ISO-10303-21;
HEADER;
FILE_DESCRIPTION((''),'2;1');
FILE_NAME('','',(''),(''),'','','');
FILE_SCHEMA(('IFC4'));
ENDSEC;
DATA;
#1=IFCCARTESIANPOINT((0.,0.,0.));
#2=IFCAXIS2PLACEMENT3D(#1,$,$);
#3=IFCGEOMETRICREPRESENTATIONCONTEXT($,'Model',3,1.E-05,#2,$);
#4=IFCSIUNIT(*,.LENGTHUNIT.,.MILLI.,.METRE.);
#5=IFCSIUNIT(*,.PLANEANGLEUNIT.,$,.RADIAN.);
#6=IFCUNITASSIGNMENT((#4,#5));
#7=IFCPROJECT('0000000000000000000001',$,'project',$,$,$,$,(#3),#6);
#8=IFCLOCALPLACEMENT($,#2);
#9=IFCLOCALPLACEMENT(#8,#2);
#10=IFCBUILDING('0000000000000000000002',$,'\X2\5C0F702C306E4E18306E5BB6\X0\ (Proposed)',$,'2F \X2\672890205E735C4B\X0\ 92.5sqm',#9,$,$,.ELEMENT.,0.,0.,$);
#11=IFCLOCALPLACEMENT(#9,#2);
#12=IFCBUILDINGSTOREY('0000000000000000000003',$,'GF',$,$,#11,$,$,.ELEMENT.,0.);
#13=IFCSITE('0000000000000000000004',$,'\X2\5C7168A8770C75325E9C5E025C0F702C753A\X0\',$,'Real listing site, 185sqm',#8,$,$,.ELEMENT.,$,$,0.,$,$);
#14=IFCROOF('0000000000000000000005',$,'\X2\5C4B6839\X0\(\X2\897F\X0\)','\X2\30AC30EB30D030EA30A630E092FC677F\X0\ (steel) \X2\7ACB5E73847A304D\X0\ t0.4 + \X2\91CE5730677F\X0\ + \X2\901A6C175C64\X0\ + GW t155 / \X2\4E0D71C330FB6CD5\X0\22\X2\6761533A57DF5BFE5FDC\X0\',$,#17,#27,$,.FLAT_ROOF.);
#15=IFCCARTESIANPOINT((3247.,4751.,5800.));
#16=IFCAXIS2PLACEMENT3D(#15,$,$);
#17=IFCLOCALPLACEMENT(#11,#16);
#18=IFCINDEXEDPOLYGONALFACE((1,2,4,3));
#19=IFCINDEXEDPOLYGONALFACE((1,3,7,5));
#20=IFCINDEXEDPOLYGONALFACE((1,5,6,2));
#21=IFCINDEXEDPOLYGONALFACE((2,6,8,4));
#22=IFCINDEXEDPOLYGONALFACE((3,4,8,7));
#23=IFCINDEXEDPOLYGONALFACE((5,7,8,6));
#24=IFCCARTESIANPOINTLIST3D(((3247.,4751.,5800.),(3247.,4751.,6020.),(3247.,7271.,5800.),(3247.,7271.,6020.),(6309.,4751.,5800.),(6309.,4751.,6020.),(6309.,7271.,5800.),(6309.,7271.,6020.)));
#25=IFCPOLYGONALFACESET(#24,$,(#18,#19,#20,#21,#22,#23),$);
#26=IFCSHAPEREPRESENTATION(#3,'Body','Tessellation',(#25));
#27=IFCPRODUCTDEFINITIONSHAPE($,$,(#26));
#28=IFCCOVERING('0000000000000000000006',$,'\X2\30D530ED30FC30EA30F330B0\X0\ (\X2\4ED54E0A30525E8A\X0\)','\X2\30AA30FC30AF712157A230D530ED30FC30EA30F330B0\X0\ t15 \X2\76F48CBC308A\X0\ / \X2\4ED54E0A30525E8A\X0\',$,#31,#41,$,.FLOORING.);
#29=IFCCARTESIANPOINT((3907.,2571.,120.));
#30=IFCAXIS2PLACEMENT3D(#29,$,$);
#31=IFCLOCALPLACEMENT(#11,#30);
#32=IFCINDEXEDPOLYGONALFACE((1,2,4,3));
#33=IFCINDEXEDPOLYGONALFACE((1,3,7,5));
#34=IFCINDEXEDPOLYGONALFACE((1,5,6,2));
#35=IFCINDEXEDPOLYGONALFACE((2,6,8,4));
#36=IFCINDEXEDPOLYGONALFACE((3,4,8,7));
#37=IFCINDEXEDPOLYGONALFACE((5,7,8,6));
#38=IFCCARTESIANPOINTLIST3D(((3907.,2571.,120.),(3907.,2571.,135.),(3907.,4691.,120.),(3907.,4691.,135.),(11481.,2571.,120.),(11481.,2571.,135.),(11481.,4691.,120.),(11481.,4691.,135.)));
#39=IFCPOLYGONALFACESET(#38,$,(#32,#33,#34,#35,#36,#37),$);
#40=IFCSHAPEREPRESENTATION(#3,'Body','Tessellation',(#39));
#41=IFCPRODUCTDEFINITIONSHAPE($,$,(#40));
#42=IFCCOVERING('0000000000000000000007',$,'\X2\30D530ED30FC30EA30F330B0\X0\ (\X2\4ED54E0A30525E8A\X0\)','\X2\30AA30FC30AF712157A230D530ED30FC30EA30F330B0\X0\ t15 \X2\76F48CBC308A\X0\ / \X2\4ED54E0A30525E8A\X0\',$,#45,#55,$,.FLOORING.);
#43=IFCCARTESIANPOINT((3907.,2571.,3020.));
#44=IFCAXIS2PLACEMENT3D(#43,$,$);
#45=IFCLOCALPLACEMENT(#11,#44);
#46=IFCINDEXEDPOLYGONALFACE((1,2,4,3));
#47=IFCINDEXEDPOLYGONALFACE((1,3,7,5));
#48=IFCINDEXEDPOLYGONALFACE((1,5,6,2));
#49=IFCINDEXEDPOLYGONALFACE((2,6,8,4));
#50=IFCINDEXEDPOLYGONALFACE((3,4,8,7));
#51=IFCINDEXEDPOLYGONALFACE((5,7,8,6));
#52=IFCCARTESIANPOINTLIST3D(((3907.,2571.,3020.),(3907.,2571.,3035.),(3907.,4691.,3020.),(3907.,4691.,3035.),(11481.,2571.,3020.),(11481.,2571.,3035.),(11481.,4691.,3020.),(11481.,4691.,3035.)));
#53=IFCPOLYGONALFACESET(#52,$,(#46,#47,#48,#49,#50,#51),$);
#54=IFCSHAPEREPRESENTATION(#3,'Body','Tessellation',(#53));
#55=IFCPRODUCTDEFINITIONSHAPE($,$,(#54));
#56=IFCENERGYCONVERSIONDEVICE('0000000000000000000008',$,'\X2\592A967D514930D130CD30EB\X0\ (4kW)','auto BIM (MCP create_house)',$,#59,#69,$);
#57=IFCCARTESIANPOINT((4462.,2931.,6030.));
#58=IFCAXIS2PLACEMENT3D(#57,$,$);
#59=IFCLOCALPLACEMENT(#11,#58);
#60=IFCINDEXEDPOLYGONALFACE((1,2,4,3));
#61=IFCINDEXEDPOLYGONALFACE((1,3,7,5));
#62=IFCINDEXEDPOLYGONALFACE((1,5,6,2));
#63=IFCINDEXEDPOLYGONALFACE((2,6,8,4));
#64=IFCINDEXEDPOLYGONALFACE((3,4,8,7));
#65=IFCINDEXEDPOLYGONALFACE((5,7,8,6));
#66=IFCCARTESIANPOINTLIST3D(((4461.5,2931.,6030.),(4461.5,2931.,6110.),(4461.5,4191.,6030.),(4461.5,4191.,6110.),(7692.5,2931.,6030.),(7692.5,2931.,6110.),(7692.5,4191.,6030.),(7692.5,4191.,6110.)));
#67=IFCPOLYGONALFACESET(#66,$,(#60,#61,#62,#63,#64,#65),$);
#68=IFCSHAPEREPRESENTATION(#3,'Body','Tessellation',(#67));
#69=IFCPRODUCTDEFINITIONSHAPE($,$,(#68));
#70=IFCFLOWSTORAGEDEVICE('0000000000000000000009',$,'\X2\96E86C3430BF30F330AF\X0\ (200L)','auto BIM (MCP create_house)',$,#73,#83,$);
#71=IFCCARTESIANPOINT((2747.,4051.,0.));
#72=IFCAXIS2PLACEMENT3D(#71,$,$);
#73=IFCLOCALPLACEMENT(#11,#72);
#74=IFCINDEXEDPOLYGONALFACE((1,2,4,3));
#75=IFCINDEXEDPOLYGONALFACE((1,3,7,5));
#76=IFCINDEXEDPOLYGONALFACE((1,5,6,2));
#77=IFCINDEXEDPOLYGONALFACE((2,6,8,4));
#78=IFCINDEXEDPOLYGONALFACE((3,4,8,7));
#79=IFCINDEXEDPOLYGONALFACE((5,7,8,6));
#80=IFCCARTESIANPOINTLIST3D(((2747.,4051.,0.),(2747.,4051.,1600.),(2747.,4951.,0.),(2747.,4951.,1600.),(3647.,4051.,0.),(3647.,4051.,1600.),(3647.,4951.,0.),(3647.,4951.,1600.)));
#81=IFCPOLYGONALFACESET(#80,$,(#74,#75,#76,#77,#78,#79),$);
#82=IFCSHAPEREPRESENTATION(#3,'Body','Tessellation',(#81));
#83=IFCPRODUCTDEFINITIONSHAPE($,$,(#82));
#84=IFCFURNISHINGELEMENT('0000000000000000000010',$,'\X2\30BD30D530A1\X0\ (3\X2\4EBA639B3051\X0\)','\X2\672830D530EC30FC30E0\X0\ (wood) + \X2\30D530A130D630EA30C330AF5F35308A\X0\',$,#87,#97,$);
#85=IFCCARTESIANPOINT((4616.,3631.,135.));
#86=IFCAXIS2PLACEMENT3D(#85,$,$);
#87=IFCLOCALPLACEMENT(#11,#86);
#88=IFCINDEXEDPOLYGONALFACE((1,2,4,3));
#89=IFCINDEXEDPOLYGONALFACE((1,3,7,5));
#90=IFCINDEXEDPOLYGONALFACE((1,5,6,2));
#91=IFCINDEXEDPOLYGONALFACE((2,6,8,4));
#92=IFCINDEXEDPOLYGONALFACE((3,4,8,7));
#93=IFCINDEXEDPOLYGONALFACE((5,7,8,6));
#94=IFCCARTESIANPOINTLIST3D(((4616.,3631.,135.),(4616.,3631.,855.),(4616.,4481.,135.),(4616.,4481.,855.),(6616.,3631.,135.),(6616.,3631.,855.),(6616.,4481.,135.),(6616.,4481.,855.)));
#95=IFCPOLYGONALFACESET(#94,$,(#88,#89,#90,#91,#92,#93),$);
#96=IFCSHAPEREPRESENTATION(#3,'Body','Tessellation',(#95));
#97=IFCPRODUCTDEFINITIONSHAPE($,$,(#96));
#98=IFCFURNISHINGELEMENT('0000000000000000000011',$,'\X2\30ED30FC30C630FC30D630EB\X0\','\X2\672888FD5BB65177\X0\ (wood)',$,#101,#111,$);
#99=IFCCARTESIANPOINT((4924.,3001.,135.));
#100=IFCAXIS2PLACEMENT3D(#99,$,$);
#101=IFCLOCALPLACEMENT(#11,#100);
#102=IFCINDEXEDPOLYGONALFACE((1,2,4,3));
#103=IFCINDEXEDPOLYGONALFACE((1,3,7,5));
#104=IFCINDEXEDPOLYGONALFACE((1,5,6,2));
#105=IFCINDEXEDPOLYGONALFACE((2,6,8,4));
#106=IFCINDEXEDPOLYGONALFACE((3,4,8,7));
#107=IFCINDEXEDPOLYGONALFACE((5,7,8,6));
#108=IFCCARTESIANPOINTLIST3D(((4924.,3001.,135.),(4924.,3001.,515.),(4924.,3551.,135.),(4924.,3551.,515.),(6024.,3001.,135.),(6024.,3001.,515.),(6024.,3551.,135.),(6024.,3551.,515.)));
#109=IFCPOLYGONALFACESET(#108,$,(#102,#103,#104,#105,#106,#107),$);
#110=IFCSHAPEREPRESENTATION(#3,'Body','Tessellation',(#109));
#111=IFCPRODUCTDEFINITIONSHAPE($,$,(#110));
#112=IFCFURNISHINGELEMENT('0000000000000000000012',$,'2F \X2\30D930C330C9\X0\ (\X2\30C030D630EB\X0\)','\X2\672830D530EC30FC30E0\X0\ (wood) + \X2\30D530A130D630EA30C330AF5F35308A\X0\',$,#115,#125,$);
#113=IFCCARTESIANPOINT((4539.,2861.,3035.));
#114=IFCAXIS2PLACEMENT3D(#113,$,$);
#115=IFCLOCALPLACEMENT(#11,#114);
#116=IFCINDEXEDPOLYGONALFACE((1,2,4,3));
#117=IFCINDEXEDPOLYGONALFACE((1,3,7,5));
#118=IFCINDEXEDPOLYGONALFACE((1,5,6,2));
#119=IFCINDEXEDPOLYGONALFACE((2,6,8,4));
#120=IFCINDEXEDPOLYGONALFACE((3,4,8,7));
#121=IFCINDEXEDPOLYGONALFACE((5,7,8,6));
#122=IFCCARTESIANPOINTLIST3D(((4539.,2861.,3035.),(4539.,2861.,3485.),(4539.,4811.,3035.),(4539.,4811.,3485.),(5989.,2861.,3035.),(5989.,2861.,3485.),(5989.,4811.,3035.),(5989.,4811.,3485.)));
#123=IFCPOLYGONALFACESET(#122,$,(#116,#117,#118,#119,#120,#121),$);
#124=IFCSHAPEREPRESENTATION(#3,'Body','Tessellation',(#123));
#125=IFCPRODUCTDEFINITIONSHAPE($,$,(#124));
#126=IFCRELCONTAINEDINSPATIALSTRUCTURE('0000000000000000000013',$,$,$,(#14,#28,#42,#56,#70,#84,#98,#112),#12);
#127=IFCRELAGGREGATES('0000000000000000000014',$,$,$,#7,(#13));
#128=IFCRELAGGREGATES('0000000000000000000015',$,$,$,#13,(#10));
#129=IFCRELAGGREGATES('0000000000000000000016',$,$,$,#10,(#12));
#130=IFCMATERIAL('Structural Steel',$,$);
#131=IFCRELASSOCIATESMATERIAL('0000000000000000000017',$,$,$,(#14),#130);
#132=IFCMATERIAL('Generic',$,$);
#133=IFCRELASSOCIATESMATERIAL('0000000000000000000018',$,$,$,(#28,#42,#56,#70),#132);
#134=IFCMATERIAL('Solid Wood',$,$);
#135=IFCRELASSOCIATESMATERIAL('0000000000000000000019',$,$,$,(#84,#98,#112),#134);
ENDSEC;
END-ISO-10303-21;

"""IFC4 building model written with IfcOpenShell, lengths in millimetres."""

from ifc_helpers import new_model, si_unit, frame, frame_2d, origin, place, context, project, spatial, rectangle, extrude, material, element, save


model = new_model("IFC4")

# Units and contexts
model_context = context("Model", 3, precision=1e-05, world=origin())
ifc_project = project(units=[si_unit("LENGTHUNIT", "METRE", prefix="MILLI"), si_unit("PLANEANGLEUNIT", "RADIAN")], contexts=[model_context])

# Site, building, storey
site_placement = place(None, origin())
site = spatial("IfcSite", under=ifc_project, at=site_placement, Name="山梨県甲府市小瀬町", ObjectType="Real listing site, 185sqm", CompositionType="ELEMENT", RefElevation=0.0)
building_placement = place(site_placement, origin())
building = spatial("IfcBuilding", under=site, at=building_placement, Name="小瀬の丘の家 (Proposed)", ObjectType="2F 木造平屋 92.5sqm", CompositionType="ELEMENT", ElevationOfRefHeight=0.0, ElevationOfTerrain=0.0)
storey_placement = place(building_placement, origin())
storey = spatial("IfcBuildingStorey", under=building, at=storey_placement, Name="GF", CompositionType="ELEMENT", Elevation=0.0)

# Shared definitions
ifc_material_1 = material(Name="Solid Wood")

# Roof
ifc_material_2 = material(Name="Structural Steel")
roof_1_placement = place(storey_placement, frame((3247.0, 4751.0, 5800.0)))
element("IfcRoof", 1, at=roof_1_placement, inside=storey, material=ifc_material_2, Name="屋根(西)", Description="ガルバリウム鋼板 (steel) 立平葺き t0.4 + 野地板 + 通気層 + GW t155 / 不燃・法22条区域対応", PredefinedType="FLAT_ROOF", context=model_context, shape_type="SweptSolid", body=[
    extrude(rectangle(XDim=3062.0, YDim=2520.0, at=frame_2d((1531.0, 1260.0))), frame((3247.0, 4751.0, 5800.0)), (0.0, 0.0, 1.0), 220.0),
])

# Coverings
ifc_material_3 = material(Name="Generic")
covering_1_placement = place(storey_placement, frame((3907.0, 2571.0, 120.0)))
element("IfcCovering", 2, at=covering_1_placement, inside=storey, material=ifc_material_3, Name="フローリング (仕上げ床)", Description="オーク無垢フローリング t15 直貼り / 仕上げ床", PredefinedType="FLOORING", context=model_context, shape_type="SweptSolid", body=[
    extrude(rectangle(XDim=7574.0, YDim=2120.0, at=frame_2d((3787.0, 1060.0))), frame((3907.0, 2571.0, 120.0)), (0.0, 0.0, 1.0), 15.0),
])
covering_2_placement = place(storey_placement, frame((3907.0, 2571.0, 3020.0)))
element("IfcCovering", 3, at=covering_2_placement, inside=storey, material=ifc_material_3, Name="フローリング (仕上げ床)", Description="オーク無垢フローリング t15 直貼り / 仕上げ床", PredefinedType="FLOORING", context=model_context, shape_type="SweptSolid", body=[
    extrude(rectangle(XDim=7574.0, YDim=2120.0, at=frame_2d((3787.0, 1060.0))), frame((3907.0, 2571.0, 3020.0)), (0.0, 0.0, 1.0), 15.0),
])

# Energy conversion device
energy_conversion_device_placement = place(storey_placement, frame((4462.0, 2931.0, 6030.0)))
element("IfcEnergyConversionDevice", 4, at=energy_conversion_device_placement, inside=storey, material=ifc_material_3, Name="太陽光パネル (4kW)", Description="auto BIM (MCP create_house)", context=model_context, shape_type="SweptSolid", body=[
    extrude(rectangle(XDim=3231.0, YDim=1260.0, at=frame_2d((1615.0, 630.0))), frame((4462.0, 2931.0, 6030.0)), (0.0, 0.0, 1.0), 80.0),
])

# Flow storage device
flow_storage_device_placement = place(storey_placement, frame((2747.0, 4051.0, 0.0)))
element("IfcFlowStorageDevice", 5, at=flow_storage_device_placement, inside=storey, material=ifc_material_3, Name="雨水タンク (200L)", Description="auto BIM (MCP create_house)", context=model_context, shape_type="SweptSolid", body=[
    extrude(rectangle(XDim=900.0, YDim=900.0, at=frame_2d((450.0, 450.0))), frame((2747.0, 4051.0, 0.0)), (0.0, 0.0, 1.0), 1600.0),
])

# Furnishing elements
furnishing_1_placement = place(storey_placement, frame((4616.0, 3631.0, 135.0)))
element("IfcFurnishingElement", 6, at=furnishing_1_placement, inside=storey, material=ifc_material_1, Name="ソファ (3人掛け)", Description="木フレーム (wood) + ファブリック張り", context=model_context, shape_type="SweptSolid", body=[
    extrude(rectangle(XDim=2000.0, YDim=850.0, at=frame_2d((1000.0, 425.0))), frame((4616.0, 3631.0, 135.0)), (0.0, 0.0, 1.0), 720.0),
])
furnishing_2_placement = place(storey_placement, frame((4924.0, 3001.0, 135.0)))
element("IfcFurnishingElement", 7, at=furnishing_2_placement, inside=storey, material=ifc_material_1, Name="ローテーブル", Description="木製家具 (wood)", context=model_context, shape_type="SweptSolid", body=[
    extrude(rectangle(XDim=1100.0, YDim=550.0, at=frame_2d((550.0, 275.0))), frame((4924.0, 3001.0, 135.0)), (0.0, 0.0, 1.0), 380.0),
])
furnishing_3_placement = place(storey_placement, frame((4539.0, 2861.0, 3035.0)))
element("IfcFurnishingElement", 8, at=furnishing_3_placement, inside=storey, material=ifc_material_1, Name="2F ベッド (ダブル)", Description="木フレーム (wood) + ファブリック張り", context=model_context, shape_type="SweptSolid", body=[
    extrude(rectangle(XDim=1450.0, YDim=1950.0, at=frame_2d((725.0, 975.0))), frame((4539.0, 2861.0, 3035.0)), (0.0, 0.0, 1.0), 450.0),
])

save(model, "model.ifc")
